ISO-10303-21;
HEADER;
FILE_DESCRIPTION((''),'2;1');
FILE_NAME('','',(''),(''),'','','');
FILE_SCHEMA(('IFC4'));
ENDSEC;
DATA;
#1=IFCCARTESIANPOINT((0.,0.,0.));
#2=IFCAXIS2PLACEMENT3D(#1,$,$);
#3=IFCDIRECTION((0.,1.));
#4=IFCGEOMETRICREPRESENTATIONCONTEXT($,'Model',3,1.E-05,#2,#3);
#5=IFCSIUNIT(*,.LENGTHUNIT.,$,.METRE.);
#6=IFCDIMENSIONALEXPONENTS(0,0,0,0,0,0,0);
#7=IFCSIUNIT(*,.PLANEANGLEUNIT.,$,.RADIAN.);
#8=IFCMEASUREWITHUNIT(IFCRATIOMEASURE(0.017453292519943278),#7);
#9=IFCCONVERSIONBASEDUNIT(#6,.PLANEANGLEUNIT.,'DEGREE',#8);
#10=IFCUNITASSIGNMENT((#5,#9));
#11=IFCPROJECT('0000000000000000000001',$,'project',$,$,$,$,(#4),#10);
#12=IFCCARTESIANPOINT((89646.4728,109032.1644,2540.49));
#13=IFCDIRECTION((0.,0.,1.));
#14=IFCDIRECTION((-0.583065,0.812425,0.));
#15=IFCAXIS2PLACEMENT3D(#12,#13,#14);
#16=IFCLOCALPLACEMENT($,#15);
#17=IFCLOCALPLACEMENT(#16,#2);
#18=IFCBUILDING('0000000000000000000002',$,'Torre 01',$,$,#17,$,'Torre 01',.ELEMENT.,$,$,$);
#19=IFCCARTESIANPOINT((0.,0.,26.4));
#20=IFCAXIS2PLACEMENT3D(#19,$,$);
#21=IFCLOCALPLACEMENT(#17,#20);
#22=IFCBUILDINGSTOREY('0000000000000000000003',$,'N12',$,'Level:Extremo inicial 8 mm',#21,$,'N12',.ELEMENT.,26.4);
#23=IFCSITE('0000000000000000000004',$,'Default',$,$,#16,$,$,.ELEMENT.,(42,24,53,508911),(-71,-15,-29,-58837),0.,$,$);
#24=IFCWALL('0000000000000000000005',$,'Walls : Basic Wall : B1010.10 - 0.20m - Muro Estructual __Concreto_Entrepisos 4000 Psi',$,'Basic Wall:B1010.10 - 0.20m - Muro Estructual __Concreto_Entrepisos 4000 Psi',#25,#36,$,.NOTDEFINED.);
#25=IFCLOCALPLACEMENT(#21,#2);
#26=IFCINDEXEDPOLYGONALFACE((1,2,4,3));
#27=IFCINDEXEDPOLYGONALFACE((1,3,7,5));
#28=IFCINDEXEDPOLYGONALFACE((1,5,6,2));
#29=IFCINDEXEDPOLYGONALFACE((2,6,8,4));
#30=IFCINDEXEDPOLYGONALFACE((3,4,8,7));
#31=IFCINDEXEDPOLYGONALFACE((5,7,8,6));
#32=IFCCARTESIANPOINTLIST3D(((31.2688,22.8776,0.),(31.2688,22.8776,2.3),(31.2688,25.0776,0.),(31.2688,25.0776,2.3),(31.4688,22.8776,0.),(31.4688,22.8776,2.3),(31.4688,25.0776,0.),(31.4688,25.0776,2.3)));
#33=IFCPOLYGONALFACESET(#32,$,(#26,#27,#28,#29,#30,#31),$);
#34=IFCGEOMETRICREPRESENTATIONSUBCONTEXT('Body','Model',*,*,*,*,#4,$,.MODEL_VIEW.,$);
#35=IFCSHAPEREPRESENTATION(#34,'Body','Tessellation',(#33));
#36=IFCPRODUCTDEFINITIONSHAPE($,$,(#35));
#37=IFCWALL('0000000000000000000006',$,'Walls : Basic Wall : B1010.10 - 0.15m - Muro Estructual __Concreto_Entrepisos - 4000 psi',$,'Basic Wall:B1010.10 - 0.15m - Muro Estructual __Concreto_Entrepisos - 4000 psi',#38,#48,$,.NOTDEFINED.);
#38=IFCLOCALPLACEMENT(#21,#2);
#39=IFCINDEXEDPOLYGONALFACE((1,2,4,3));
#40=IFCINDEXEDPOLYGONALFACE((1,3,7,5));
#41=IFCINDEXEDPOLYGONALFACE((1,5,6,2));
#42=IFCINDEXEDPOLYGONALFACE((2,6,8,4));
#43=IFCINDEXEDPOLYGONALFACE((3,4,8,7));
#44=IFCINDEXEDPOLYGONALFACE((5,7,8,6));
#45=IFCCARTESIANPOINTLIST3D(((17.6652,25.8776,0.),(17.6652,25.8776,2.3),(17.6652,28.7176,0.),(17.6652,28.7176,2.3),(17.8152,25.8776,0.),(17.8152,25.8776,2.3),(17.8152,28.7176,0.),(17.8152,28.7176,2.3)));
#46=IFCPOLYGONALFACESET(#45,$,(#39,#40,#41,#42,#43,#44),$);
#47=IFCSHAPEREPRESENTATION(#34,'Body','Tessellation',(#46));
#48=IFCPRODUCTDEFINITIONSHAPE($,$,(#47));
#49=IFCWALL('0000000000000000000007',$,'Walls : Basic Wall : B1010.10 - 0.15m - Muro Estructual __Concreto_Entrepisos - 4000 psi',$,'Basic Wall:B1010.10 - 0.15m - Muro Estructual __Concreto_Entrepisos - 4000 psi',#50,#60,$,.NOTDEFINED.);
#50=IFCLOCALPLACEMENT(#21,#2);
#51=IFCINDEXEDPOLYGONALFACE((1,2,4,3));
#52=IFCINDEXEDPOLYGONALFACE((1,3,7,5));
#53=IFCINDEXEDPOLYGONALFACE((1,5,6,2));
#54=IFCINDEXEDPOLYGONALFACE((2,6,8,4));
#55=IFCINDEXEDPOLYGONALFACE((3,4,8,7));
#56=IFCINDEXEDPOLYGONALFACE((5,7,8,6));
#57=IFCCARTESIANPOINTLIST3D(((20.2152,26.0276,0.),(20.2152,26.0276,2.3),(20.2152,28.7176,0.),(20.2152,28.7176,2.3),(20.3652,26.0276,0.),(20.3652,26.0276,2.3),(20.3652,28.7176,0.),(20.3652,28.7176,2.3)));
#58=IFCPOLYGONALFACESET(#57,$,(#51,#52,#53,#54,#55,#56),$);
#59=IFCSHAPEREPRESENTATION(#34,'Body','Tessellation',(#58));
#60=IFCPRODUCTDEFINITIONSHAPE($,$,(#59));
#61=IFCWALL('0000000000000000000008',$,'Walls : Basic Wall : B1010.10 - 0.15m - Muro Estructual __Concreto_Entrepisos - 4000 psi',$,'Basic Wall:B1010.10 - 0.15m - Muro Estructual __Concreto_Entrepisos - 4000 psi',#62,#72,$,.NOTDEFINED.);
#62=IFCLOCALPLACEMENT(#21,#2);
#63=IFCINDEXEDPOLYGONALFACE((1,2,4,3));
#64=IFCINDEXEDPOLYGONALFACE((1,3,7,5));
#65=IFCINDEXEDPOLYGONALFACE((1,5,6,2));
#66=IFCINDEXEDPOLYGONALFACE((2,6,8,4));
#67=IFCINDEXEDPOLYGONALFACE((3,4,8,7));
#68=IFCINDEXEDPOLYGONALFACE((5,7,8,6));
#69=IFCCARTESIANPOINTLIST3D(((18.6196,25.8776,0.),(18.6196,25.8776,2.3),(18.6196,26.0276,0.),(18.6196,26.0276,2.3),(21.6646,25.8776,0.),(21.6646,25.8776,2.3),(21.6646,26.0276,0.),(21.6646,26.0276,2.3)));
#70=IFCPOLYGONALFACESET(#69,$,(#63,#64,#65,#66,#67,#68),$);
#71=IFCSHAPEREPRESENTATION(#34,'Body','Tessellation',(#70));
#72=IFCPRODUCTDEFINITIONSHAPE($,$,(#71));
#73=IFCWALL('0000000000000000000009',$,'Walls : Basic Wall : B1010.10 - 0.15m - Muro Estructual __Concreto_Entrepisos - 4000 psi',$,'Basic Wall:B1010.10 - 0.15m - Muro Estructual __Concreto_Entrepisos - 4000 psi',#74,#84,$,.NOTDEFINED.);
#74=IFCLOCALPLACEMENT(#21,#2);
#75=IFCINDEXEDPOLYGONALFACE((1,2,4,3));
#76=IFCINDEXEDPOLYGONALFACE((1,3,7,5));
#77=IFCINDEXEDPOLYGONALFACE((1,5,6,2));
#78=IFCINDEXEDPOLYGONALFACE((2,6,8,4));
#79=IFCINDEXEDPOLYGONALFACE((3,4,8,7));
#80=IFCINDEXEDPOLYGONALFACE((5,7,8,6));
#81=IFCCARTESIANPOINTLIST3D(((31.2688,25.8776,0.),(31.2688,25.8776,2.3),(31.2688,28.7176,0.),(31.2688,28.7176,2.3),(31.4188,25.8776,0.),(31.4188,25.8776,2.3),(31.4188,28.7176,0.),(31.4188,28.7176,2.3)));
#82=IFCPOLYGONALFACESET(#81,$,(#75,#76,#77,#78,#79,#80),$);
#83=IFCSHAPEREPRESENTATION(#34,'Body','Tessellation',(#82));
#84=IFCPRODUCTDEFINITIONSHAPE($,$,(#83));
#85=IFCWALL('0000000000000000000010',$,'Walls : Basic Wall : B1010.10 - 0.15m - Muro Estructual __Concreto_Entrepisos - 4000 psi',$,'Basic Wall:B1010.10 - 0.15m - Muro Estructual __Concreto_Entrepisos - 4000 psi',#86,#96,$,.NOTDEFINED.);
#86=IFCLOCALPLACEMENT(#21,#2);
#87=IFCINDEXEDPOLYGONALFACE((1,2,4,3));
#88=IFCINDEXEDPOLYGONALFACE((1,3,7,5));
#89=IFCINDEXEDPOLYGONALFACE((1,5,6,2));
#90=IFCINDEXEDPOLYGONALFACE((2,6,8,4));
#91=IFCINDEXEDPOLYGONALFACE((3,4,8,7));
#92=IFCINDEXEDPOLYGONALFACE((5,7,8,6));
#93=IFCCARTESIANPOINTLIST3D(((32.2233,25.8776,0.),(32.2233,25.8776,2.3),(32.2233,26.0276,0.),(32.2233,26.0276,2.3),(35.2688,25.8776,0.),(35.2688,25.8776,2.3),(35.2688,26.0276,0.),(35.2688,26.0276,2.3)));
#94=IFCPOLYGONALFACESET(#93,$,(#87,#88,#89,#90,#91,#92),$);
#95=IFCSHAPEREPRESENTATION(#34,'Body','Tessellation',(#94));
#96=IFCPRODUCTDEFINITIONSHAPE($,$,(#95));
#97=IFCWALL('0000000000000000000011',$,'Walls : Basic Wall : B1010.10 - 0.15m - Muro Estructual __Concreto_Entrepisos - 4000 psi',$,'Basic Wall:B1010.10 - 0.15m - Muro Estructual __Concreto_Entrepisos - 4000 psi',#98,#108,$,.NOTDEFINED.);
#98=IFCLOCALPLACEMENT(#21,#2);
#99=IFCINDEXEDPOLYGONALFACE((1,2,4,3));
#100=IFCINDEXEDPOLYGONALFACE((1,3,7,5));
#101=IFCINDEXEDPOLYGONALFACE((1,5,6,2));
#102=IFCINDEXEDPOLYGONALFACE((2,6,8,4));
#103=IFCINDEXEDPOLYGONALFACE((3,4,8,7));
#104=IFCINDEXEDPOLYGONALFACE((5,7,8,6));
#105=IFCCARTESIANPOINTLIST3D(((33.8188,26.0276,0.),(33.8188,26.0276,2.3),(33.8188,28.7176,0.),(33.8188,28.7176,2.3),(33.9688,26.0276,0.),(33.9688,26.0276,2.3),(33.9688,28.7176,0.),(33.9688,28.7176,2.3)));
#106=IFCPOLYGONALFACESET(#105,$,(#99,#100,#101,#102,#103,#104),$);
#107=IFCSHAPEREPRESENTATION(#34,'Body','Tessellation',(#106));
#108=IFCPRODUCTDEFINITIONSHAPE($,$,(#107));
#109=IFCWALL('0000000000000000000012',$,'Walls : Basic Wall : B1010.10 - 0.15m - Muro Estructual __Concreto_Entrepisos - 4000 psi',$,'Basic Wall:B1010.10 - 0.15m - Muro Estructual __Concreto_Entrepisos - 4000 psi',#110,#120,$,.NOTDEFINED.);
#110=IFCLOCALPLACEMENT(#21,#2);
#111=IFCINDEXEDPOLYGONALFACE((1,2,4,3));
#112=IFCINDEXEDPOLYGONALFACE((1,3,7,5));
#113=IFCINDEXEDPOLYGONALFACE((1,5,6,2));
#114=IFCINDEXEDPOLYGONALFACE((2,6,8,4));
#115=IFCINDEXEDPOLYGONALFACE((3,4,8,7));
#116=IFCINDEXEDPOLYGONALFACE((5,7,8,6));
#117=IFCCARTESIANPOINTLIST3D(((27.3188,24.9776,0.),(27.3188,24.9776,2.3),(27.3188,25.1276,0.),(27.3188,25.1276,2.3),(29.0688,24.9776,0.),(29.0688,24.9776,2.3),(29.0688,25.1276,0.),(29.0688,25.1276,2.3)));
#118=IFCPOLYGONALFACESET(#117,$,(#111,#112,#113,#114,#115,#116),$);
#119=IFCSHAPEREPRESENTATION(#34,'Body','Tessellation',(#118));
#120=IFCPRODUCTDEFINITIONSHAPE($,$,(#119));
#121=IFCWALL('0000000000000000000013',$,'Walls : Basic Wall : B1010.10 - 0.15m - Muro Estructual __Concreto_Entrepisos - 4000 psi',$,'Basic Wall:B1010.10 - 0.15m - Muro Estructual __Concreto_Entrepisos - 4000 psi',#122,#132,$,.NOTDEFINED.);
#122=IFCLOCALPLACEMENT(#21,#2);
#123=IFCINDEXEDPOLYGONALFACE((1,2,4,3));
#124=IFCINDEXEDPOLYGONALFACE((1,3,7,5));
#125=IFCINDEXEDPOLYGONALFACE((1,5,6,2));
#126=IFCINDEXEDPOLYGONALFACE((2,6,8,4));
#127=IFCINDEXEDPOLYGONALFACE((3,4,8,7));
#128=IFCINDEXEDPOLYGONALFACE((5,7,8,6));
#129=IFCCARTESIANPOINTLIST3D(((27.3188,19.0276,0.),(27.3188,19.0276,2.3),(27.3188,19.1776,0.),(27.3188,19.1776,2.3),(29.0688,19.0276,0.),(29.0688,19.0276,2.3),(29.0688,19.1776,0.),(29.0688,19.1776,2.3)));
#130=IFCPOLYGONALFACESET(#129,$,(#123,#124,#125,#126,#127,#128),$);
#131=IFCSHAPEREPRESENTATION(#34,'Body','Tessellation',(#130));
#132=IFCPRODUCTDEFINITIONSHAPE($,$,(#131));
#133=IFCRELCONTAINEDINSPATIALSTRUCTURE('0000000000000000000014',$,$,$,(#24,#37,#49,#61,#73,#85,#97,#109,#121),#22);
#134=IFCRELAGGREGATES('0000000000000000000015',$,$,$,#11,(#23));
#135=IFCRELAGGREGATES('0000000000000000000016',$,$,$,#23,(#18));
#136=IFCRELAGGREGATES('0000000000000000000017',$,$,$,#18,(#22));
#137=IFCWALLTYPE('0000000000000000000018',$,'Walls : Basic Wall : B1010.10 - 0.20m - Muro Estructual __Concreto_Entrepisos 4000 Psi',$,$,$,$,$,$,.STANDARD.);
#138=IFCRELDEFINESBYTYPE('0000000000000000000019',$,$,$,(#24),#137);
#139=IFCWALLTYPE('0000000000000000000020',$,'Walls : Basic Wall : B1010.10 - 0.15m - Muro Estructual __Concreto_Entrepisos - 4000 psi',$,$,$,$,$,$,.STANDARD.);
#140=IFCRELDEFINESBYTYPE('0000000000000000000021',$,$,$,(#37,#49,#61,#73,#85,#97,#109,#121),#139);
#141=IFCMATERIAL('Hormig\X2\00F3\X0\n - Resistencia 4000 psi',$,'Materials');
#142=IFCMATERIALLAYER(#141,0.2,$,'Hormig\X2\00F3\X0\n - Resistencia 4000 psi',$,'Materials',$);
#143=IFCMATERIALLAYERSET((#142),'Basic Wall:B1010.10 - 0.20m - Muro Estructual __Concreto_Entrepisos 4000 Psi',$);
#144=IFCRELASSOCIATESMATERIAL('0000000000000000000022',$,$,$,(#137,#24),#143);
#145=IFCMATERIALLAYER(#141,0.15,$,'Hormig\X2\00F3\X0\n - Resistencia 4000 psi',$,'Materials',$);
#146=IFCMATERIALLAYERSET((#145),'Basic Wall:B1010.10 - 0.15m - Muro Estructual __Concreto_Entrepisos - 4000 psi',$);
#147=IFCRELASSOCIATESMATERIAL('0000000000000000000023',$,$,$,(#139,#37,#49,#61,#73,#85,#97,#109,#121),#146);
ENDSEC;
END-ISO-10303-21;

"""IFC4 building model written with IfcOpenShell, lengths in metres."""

from ifc_helpers import new_model, entity, si_unit, converted_unit, direction, frame, frame_2d, origin, place, context, subcontext, project, spatial, rectangle, extrude, material, layer, layer_set, layer_usage, type_object, element, save


model = new_model("IFC4")

# Units and contexts
model_context = context("Model", 3, precision=1e-05, world=origin(), true_north=direction((0.0, 1.0)))
body_context = subcontext(model_context, "Body", "Model", "MODEL_VIEW")
ifc_project = project(units=[si_unit("LENGTHUNIT", "METRE"), converted_unit("PLANEANGLEUNIT", "DEGREE", entity("IfcRatioMeasure", 0.017453292519943278), si_unit("PLANEANGLEUNIT", "RADIAN"), dimensions=[0, 0, 0, 0, 0, 0, 0])], contexts=[model_context])

# Site, building, storey
site_placement = place(None, frame((89646.4728, 109032.1644, 2540.49), z_axis=(0.0, 0.0, 1.0), x_axis=(-0.583065, 0.812425, 0.0)))
site = spatial("IfcSite", under=ifc_project, at=site_placement, Name="Default", CompositionType="ELEMENT", RefLatitude=(42, 24, 53, 508911), RefLongitude=(-71, -15, -29, -58837), RefElevation=0.0)
building_placement = place(site_placement, origin())
building = spatial("IfcBuilding", under=site, at=building_placement, Name="Torre 01", LongName="Torre 01", CompositionType="ELEMENT")
storey_placement = place(building_placement, frame((0.0, 0.0, 26.4)))
storey = spatial("IfcBuildingStorey", under=building, at=storey_placement, Name="N12", ObjectType="Level:Extremo inicial 8 mm", LongName="N12", CompositionType="ELEMENT", Elevation=26.4)

# Walls
ifc_material = material(Name="Hormigón - Resistencia 4000 psi", Category="Materials")
ifc_layer_1 = layer(ifc_material, 0.2, Name="Hormigón - Resistencia 4000 psi", Category="Materials")
ifc_layer_set_1 = layer_set([ifc_layer_1], Name="Basic Wall:B1010.10 - 0.20m - Muro Estructual __Concreto_Entrepisos 4000 Psi")
wall_type_1 = type_object("IfcWallType", Name="Walls : Basic Wall : B1010.10 - 0.20m - Muro Estructual __Concreto_Entrepisos 4000 Psi", PredefinedType="STANDARD", material=ifc_layer_set_1)
ifc_layer_usage_1 = layer_usage(ifc_layer_set_1, "AXIS2", "POSITIVE", -0.1)
wall_1_placement = place(storey_placement, frame((31.3688, 22.8776, 0.0), z_axis=(0.0, 0.0, 1.0), x_axis=(0.0, 1.0, 0.0)))
element("IfcWall", 1, at=wall_1_placement, inside=storey, type_object=wall_type_1, material=ifc_layer_usage_1, Name="Walls : Basic Wall : B1010.10 - 0.20m - Muro Estructual __Concreto_Entrepisos 4000 Psi", ObjectType="Basic Wall:B1010.10 - 0.20m - Muro Estructual __Concreto_Entrepisos 4000 Psi", PredefinedType="NOTDEFINED", context=body_context, shape_type="SweptSolid", body=[
    extrude(rectangle(XDim=2.2, YDim=0.2, at=frame_2d((1.1, 0.0), x_axis=(-1.0, 0.0))), origin(), (0.0, 0.0, 1.0), 2.3),
])
ifc_layer_2 = layer(ifc_material, 0.15, Name="Hormigón - Resistencia 4000 psi", Category="Materials")
ifc_layer_set_2 = layer_set([ifc_layer_2], Name="Basic Wall:B1010.10 - 0.15m - Muro Estructual __Concreto_Entrepisos - 4000 psi")
ifc_layer_usage_2 = layer_usage(ifc_layer_set_2, "AXIS2", "POSITIVE", -0.075)
wall_type_2 = type_object("IfcWallType", Name="Walls : Basic Wall : B1010.10 - 0.15m - Muro Estructual __Concreto_Entrepisos - 4000 psi", PredefinedType="STANDARD", material=ifc_layer_set_2)
wall_2_placement = place(storey_placement, frame((17.7402, 25.8776, 0.0), z_axis=(0.0, 0.0, 1.0), x_axis=(0.0, 1.0, 0.0)))
element("IfcWall", 2, at=wall_2_placement, inside=storey, type_object=wall_type_2, material=ifc_layer_usage_2, Name="Walls : Basic Wall : B1010.10 - 0.15m - Muro Estructual __Concreto_Entrepisos - 4000 psi", ObjectType="Basic Wall:B1010.10 - 0.15m - Muro Estructual __Concreto_Entrepisos - 4000 psi", PredefinedType="NOTDEFINED", context=body_context, shape_type="SweptSolid", body=[
    extrude(rectangle(XDim=2.84, YDim=0.15, at=frame_2d((1.42, 0.0), x_axis=(-1.0, 0.0))), origin(), (0.0, 0.0, 1.0), 2.3),
])
ifc_layer_usage_3 = layer_usage(ifc_layer_set_2, "AXIS2", "POSITIVE", -0.075)
wall_3_placement = place(storey_placement, frame((20.2902, 28.7176, 0.0), z_axis=(0.0, 0.0, 1.0), x_axis=(0.0, -1.0, 0.0)))
element("IfcWall", 3, at=wall_3_placement, inside=storey, type_object=wall_type_2, material=ifc_layer_usage_3, Name="Walls : Basic Wall : B1010.10 - 0.15m - Muro Estructual __Concreto_Entrepisos - 4000 psi", ObjectType="Basic Wall:B1010.10 - 0.15m - Muro Estructual __Concreto_Entrepisos - 4000 psi", PredefinedType="NOTDEFINED", context=body_context, shape_type="SweptSolid", body=[
    extrude(rectangle(XDim=2.69, YDim=0.15, at=frame_2d((1.345, 0.0), x_axis=(-1.0, 0.0))), origin(), (0.0, 0.0, 1.0), 2.3),
])
ifc_layer_usage_4 = layer_usage(ifc_layer_set_2, "AXIS2", "POSITIVE", -0.075)
wall_4_placement = place(storey_placement, frame((18.6196, 25.9526, 0.0)))
element("IfcWall", 4, at=wall_4_placement, inside=storey, type_object=wall_type_2, material=ifc_layer_usage_4, Name="Walls : Basic Wall : B1010.10 - 0.15m - Muro Estructual __Concreto_Entrepisos - 4000 psi", ObjectType="Basic Wall:B1010.10 - 0.15m - Muro Estructual __Concreto_Entrepisos - 4000 psi", PredefinedType="NOTDEFINED", context=body_context, shape_type="SweptSolid", body=[
    extrude(rectangle(XDim=3.045, YDim=0.15, at=frame_2d((1.5225, 0.0), x_axis=(-1.0, 0.0))), origin(), (0.0, 0.0, 1.0), 2.3),
])
ifc_layer_usage_5 = layer_usage(ifc_layer_set_2, "AXIS2", "POSITIVE", -0.075)
wall_5_placement = place(storey_placement, frame((31.3438, 28.7176, 0.0), z_axis=(0.0, 0.0, 1.0), x_axis=(0.0, -1.0, 0.0)))
element("IfcWall", 5, at=wall_5_placement, inside=storey, type_object=wall_type_2, material=ifc_layer_usage_5, Name="Walls : Basic Wall : B1010.10 - 0.15m - Muro Estructual __Concreto_Entrepisos - 4000 psi", ObjectType="Basic Wall:B1010.10 - 0.15m - Muro Estructual __Concreto_Entrepisos - 4000 psi", PredefinedType="NOTDEFINED", context=body_context, shape_type="SweptSolid", body=[
    extrude(rectangle(XDim=2.84, YDim=0.15, at=frame_2d((1.42, 0.0), x_axis=(-1.0, 0.0))), origin(), (0.0, 0.0, 1.0), 2.3),
])
ifc_layer_usage_6 = layer_usage(ifc_layer_set_2, "AXIS2", "POSITIVE", -0.075)
wall_6_placement = place(storey_placement, frame((32.2233, 25.9526, 0.0)))
element("IfcWall", 6, at=wall_6_placement, inside=storey, type_object=wall_type_2, material=ifc_layer_usage_6, Name="Walls : Basic Wall : B1010.10 - 0.15m - Muro Estructual __Concreto_Entrepisos - 4000 psi", ObjectType="Basic Wall:B1010.10 - 0.15m - Muro Estructual __Concreto_Entrepisos - 4000 psi", PredefinedType="NOTDEFINED", context=body_context, shape_type="SweptSolid", body=[
    extrude(rectangle(XDim=3.0455, YDim=0.15, at=frame_2d((1.5228, 0.0), x_axis=(-1.0, 0.0))), origin(), (0.0, 0.0, 1.0), 2.3),
])
ifc_layer_usage_7 = layer_usage(ifc_layer_set_2, "AXIS2", "POSITIVE", -0.075)
wall_7_placement = place(storey_placement, frame((33.8938, 26.0276, 0.0), z_axis=(0.0, 0.0, 1.0), x_axis=(0.0, 1.0, 0.0)))
element("IfcWall", 7, at=wall_7_placement, inside=storey, type_object=wall_type_2, material=ifc_layer_usage_7, Name="Walls : Basic Wall : B1010.10 - 0.15m - Muro Estructual __Concreto_Entrepisos - 4000 psi", ObjectType="Basic Wall:B1010.10 - 0.15m - Muro Estructual __Concreto_Entrepisos - 4000 psi", PredefinedType="NOTDEFINED", context=body_context, shape_type="SweptSolid", body=[
    extrude(rectangle(XDim=2.69, YDim=0.15, at=frame_2d((1.345, 0.0), x_axis=(-1.0, 0.0))), origin(), (0.0, 0.0, 1.0), 2.3),
])
ifc_layer_usage_8 = layer_usage(ifc_layer_set_2, "AXIS2", "NEGATIVE", 0.075)
wall_8_placement = place(storey_placement, frame((29.0688, 25.0526, 0.0), z_axis=(0.0, 0.0, 1.0), x_axis=(-1.0, 0.0, 0.0)))
element("IfcWall", 8, at=wall_8_placement, inside=storey, type_object=wall_type_2, material=ifc_layer_usage_8, Name="Walls : Basic Wall : B1010.10 - 0.15m - Muro Estructual __Concreto_Entrepisos - 4000 psi", ObjectType="Basic Wall:B1010.10 - 0.15m - Muro Estructual __Concreto_Entrepisos - 4000 psi", PredefinedType="NOTDEFINED", context=body_context, shape_type="SweptSolid", body=[
    extrude(rectangle(XDim=1.75, YDim=0.15, at=frame_2d((0.875, 0.0), x_axis=(-1.0, 0.0))), origin(), (0.0, 0.0, 1.0), 2.3),
])
ifc_layer_usage_9 = layer_usage(ifc_layer_set_2, "AXIS2", "POSITIVE", -0.075)
wall_9_placement = place(storey_placement, frame((29.0688, 19.1026, 0.0), z_axis=(0.0, 0.0, 1.0), x_axis=(-1.0, 0.0, 0.0)))
element("IfcWall", 9, at=wall_9_placement, inside=storey, type_object=wall_type_2, material=ifc_layer_usage_9, Name="Walls : Basic Wall : B1010.10 - 0.15m - Muro Estructual __Concreto_Entrepisos - 4000 psi", ObjectType="Basic Wall:B1010.10 - 0.15m - Muro Estructual __Concreto_Entrepisos - 4000 psi", PredefinedType="NOTDEFINED", context=body_context, shape_type="SweptSolid", body=[
    extrude(rectangle(XDim=1.75, YDim=0.15, at=frame_2d((0.875, 0.0), x_axis=(-1.0, 0.0))), origin(), (0.0, 0.0, 1.0), 2.3),
])

save(model, "model.ifc")
